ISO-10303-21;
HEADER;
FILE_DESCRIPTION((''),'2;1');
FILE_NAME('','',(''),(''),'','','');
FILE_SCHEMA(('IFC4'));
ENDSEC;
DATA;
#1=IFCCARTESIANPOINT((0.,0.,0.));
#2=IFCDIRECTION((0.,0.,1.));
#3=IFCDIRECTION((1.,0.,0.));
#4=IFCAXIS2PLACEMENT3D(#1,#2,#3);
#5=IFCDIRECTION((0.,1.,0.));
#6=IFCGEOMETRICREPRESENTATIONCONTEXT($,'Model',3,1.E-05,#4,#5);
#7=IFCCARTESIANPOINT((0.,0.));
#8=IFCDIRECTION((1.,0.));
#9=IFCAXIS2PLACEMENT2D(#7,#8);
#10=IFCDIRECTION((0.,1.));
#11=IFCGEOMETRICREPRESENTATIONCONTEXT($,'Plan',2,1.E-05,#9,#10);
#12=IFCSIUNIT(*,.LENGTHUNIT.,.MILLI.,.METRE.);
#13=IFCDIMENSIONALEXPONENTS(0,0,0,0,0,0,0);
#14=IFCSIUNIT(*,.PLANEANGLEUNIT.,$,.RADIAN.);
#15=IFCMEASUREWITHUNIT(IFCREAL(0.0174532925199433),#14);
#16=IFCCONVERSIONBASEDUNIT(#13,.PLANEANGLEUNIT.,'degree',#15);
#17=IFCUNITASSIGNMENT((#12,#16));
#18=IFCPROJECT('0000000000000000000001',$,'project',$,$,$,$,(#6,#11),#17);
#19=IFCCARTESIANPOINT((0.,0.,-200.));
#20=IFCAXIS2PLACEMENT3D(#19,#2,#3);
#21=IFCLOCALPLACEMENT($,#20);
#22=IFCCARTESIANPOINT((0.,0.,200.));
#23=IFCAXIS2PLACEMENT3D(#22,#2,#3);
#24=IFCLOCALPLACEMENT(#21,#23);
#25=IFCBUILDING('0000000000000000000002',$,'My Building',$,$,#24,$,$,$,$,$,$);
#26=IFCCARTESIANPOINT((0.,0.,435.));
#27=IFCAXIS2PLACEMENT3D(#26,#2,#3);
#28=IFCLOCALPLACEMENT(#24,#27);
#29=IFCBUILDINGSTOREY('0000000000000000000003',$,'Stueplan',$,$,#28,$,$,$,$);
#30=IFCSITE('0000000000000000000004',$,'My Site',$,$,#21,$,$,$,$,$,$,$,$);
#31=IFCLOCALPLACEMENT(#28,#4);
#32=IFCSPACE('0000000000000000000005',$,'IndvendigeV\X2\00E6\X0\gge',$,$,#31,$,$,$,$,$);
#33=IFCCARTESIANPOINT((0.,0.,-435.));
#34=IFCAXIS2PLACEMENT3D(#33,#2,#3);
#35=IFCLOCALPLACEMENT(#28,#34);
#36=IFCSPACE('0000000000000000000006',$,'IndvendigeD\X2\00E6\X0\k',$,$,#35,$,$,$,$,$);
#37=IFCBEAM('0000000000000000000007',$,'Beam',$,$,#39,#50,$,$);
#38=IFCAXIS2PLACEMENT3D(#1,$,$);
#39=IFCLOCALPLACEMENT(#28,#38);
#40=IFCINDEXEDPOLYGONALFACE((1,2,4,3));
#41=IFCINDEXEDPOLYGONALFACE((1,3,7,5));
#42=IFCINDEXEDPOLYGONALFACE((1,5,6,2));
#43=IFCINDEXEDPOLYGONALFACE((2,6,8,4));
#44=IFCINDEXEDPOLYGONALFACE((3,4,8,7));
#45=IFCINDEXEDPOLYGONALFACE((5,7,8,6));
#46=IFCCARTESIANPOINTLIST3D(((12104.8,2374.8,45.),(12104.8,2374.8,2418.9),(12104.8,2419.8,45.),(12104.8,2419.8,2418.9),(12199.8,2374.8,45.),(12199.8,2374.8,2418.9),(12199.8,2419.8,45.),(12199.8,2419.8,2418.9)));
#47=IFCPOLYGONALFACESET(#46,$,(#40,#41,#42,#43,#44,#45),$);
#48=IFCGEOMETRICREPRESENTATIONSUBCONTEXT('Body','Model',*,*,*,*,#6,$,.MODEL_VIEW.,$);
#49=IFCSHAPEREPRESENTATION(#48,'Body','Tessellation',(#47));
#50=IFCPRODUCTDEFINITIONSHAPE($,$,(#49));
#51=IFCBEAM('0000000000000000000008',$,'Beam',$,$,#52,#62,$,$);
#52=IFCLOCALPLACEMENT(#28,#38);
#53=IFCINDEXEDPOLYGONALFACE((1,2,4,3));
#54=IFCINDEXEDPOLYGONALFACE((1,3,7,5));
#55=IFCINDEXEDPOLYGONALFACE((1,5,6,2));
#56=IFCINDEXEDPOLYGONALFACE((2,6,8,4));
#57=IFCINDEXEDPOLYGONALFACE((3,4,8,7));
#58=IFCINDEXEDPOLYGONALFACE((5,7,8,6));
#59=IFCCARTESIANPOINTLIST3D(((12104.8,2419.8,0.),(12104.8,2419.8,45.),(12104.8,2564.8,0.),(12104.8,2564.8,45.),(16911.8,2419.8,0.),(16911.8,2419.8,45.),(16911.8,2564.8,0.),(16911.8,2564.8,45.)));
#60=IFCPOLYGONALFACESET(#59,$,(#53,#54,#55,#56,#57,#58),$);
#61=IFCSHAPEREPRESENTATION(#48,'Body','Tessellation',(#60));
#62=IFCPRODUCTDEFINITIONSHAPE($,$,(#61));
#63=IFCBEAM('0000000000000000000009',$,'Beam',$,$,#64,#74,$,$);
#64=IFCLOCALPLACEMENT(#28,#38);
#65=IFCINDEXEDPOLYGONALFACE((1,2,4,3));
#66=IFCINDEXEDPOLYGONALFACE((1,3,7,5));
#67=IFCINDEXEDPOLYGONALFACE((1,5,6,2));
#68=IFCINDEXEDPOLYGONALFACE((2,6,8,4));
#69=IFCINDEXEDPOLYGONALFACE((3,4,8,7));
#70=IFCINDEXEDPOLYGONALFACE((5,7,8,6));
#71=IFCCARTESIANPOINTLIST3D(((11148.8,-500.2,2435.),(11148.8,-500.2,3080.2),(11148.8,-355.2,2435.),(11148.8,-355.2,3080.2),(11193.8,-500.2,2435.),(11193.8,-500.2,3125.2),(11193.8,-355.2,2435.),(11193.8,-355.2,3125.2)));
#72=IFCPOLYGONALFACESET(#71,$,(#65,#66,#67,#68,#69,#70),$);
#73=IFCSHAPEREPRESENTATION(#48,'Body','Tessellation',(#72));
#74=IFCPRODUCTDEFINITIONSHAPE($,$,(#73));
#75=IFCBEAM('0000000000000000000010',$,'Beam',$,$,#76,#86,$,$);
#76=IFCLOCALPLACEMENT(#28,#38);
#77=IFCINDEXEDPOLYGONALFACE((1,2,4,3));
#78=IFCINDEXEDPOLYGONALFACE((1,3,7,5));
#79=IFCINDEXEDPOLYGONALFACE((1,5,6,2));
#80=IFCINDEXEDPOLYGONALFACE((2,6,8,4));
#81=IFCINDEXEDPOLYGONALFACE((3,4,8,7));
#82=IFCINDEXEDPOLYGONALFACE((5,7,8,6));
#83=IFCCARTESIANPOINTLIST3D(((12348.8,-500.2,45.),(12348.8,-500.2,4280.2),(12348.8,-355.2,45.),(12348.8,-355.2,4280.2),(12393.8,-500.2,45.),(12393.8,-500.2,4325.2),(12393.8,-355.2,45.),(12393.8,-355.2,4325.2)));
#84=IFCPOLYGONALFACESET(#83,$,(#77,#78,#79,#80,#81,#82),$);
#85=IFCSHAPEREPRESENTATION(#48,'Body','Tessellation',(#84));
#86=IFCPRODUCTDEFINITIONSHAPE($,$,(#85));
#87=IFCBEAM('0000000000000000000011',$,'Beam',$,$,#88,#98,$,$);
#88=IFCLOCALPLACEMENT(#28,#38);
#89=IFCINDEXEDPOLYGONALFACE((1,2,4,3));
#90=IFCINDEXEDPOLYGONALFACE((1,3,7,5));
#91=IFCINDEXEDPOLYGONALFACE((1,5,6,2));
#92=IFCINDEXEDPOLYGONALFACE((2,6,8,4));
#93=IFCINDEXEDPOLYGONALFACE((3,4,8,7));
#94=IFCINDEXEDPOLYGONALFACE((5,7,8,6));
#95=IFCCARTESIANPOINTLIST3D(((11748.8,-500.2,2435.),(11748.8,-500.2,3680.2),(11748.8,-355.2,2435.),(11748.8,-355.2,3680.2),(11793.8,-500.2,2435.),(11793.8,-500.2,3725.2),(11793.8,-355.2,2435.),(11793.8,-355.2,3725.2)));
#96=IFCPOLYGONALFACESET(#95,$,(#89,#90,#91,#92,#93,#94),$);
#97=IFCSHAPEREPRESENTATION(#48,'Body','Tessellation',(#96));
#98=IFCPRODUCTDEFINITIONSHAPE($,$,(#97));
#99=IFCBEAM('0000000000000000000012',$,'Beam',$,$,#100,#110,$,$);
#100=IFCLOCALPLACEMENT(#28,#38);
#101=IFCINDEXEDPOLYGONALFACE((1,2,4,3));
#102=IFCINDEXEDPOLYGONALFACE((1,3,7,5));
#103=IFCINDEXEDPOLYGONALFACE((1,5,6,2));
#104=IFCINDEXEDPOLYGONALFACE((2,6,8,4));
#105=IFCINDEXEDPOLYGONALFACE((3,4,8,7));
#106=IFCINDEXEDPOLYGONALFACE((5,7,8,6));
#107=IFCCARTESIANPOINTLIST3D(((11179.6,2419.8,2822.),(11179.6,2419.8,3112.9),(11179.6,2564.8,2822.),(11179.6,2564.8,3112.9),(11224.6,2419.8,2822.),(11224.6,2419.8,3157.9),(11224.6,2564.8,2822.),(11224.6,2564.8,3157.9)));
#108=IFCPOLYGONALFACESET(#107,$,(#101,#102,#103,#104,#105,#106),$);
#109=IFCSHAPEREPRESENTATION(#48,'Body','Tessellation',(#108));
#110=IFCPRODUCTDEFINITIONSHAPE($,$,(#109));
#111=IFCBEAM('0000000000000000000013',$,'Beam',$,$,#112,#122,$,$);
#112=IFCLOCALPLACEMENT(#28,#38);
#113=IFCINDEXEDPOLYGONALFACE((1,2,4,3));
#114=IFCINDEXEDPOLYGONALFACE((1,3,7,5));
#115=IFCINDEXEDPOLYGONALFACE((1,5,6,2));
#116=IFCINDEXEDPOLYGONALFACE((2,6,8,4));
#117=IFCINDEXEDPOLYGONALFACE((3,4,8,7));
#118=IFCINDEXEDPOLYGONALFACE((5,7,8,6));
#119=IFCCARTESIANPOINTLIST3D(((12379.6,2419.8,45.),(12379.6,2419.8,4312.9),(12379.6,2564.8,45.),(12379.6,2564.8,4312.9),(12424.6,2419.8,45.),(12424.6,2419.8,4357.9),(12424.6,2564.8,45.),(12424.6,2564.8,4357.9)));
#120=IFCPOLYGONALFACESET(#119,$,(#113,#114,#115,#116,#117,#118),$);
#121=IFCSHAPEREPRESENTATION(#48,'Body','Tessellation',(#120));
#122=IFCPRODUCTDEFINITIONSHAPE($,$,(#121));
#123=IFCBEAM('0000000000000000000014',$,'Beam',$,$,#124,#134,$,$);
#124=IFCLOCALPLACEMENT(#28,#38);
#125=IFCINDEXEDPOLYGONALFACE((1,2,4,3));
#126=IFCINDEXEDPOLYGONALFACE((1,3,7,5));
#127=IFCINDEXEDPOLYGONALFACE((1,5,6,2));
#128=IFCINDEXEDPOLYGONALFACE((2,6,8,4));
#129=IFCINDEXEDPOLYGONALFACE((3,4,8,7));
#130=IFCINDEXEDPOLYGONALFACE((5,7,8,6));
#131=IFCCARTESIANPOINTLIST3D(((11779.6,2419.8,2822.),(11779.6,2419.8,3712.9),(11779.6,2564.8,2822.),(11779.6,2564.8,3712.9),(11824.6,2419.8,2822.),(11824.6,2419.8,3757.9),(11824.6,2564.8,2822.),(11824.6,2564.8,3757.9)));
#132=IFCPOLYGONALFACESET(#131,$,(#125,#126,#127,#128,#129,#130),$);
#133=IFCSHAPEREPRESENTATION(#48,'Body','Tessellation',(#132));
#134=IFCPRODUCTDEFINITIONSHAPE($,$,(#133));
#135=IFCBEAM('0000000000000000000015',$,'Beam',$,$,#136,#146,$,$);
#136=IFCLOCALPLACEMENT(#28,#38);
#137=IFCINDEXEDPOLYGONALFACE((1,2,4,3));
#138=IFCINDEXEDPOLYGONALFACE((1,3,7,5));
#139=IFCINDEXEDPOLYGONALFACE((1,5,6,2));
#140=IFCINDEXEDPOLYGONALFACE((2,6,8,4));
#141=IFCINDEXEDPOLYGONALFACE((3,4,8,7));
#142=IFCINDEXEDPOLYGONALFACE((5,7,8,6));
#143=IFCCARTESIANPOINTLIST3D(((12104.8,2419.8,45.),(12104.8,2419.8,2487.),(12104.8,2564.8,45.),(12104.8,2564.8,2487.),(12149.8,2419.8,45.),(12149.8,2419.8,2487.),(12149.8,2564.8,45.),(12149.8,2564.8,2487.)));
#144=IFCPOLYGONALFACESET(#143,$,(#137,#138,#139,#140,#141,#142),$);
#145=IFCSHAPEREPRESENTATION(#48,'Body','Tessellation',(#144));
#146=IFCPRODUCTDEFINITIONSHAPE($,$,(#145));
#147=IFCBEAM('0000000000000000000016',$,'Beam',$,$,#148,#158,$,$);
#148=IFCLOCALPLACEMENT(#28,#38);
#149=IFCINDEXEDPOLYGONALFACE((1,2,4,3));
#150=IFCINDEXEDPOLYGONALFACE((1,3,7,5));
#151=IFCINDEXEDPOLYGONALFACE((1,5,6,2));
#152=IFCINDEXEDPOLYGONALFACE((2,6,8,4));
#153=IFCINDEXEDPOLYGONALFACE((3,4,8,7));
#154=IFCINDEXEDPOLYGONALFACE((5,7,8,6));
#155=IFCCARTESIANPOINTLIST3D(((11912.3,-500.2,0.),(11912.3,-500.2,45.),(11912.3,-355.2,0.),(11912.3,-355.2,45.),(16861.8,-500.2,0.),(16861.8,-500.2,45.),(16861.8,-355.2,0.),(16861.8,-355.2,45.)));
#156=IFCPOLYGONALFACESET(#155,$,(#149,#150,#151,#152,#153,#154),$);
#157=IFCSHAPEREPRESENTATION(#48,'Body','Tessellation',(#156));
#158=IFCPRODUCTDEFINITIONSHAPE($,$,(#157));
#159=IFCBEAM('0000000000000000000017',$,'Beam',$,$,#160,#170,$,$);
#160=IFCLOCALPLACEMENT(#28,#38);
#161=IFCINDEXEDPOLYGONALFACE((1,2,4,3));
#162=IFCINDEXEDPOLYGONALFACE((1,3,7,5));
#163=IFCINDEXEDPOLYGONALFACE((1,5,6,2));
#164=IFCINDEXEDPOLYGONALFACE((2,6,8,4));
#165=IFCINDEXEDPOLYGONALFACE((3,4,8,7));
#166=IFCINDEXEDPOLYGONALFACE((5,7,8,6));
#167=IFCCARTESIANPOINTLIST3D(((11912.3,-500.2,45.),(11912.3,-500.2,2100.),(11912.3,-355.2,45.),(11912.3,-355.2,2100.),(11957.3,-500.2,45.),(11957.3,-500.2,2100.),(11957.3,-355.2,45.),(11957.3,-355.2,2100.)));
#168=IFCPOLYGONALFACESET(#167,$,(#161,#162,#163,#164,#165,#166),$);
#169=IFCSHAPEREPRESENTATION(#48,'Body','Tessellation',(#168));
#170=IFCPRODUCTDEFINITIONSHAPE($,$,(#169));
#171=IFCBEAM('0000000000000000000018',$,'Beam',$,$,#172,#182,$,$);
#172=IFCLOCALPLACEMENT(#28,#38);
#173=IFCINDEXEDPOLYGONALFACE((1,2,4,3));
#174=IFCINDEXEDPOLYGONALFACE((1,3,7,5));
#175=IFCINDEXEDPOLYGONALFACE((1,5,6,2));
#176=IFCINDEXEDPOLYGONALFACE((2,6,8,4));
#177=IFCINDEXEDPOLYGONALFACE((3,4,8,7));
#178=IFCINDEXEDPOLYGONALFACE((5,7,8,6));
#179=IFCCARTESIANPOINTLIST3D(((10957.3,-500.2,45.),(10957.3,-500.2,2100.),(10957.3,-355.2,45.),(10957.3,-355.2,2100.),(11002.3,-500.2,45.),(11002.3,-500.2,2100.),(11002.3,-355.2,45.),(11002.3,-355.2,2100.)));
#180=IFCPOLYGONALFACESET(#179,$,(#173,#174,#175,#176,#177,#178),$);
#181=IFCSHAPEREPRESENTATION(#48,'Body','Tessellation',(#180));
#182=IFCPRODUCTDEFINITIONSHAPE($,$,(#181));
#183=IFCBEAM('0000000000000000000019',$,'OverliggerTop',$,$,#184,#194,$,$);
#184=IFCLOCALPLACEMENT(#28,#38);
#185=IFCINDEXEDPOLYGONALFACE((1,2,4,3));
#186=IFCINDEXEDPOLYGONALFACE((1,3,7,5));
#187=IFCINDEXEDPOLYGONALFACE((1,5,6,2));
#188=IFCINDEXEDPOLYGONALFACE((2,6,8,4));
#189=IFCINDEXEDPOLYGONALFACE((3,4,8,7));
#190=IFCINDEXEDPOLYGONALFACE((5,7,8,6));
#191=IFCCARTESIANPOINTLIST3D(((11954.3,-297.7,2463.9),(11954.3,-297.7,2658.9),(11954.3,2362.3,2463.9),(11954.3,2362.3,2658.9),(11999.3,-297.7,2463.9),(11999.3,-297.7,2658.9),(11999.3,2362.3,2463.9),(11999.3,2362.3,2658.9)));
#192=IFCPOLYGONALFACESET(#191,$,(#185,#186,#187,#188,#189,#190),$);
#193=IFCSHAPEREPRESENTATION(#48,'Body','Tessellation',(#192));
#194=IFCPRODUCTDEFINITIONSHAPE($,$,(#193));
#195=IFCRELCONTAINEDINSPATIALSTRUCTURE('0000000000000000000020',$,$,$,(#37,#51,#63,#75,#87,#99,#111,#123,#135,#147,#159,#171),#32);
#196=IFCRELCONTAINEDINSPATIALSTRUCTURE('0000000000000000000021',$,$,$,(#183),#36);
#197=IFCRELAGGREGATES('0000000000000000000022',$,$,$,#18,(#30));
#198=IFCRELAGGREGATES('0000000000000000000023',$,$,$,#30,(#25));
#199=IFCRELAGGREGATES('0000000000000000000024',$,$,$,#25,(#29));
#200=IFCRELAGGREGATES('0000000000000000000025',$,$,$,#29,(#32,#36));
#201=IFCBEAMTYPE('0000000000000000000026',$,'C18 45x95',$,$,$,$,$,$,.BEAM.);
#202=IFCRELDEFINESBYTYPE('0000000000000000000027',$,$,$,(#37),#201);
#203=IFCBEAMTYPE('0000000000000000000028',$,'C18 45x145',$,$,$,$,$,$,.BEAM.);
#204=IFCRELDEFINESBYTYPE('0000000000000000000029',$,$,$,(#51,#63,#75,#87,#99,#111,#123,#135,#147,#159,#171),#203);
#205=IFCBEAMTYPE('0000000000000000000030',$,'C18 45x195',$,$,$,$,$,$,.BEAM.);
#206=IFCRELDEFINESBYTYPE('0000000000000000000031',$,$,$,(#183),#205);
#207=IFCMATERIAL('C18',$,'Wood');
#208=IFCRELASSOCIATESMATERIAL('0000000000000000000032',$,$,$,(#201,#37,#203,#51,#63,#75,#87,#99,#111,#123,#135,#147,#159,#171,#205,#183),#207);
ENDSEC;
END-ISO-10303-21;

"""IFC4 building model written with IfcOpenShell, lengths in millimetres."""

from ifc_helpers import new_model, entity, si_unit, converted_unit, direction, frame, origin_with_axes, origin_2d_with_axis, place, context, subcontext, project, spatial, rectangle, extrude, clip, halfspace, material, material_profile, profile_set, profile_usage, type_object, element, save


model = new_model("IFC4")

# Units and contexts
model_context = context("Model", 3, precision=1e-05, world=origin_with_axes(), true_north=direction((0.0, 1.0, 0.0)))
plan_context = context("Plan", 2, precision=1e-05, world=origin_2d_with_axis(), true_north=direction((0.0, 1.0)))
body_context_1 = subcontext(model_context, "Body", "Model", "MODEL_VIEW")
ifc_project = project(units=[si_unit("LENGTHUNIT", "METRE", prefix="MILLI"), converted_unit("PLANEANGLEUNIT", "degree", entity("IfcReal", 0.0174532925199433), si_unit("PLANEANGLEUNIT", "RADIAN"), dimensions=[0, 0, 0, 0, 0, 0, 0])], contexts=[model_context, plan_context])

# Site, building, storey
site_placement = place(None, frame((0.0, 0.0, -200.0), z_axis=(0.0, 0.0, 1.0), x_axis=(1.0, 0.0, 0.0)))
site = spatial("IfcSite", under=ifc_project, at=site_placement, Name="My Site")
building_placement = place(site_placement, frame((0.0, 0.0, 200.0), z_axis=(0.0, 0.0, 1.0), x_axis=(1.0, 0.0, 0.0)))
building = spatial("IfcBuilding", under=site, at=building_placement, Name="My Building")
storey_placement = place(building_placement, frame((0.0, 0.0, 435.0), z_axis=(0.0, 0.0, 1.0), x_axis=(1.0, 0.0, 0.0)))
storey = spatial("IfcBuildingStorey", under=building, at=storey_placement, Name="Stueplan")

# Shared definitions
ifc_material = material(Name="C18", Category="Wood")

# Shared definitions
space_1_placement = place(storey_placement, frame((0.0, 0.0, 0.0), z_axis=(0.0, 0.0, 1.0), x_axis=(1.0, 0.0, 0.0)))
space_1 = spatial("IfcSpace", under=storey, at=space_1_placement, Name="IndvendigeVægge")

# Beams
ifc_material_profile_1 = material_profile(ifc_material, rectangle(XDim=45.0, YDim=95.0))
ifc_profile_set_1 = profile_set([ifc_material_profile_1], Name="woodStructural")
beam_type_1 = type_object("IfcBeamType", Name="C18 45x95", PredefinedType="BEAM", material=ifc_profile_set_1)
ifc_profile_usage_1 = profile_usage(ifc_profile_set_1)
beam_1_placement = place(space_1_placement, frame((12152.3, 2397.3, 45.0), z_axis=(0.0, 0.0, 1.0), x_axis=(0.0, 1.0, 0.0)))
element("IfcBeam", 1, at=beam_1_placement, inside=space_1, type_object=beam_type_1, material=ifc_profile_usage_1, Name="Beam", context=body_context_1, shape_type="SweptSolid", body=[
    extrude(rectangle(XDim=45.0, YDim=95.0), origin_with_axes(), (0.0, 0.0, 1.0), 2373.9),
])
ifc_material_profile_2 = material_profile(ifc_material, rectangle(XDim=45.0, YDim=145.0))
ifc_profile_set_2 = profile_set([ifc_material_profile_2], Name="woodStructural")
ifc_profile_usage_2 = profile_usage(ifc_profile_set_2)
beam_type_2 = type_object("IfcBeamType", Name="C18 45x145", PredefinedType="BEAM", material=ifc_profile_set_2)
beam_2_placement = place(space_1_placement, frame((12104.8, 2492.3, 22.5), z_axis=(1.0, 0.0, 0.0), x_axis=(0.0, 0.0, 1.0)))
element("IfcBeam", 2, at=beam_2_placement, inside=space_1, type_object=beam_type_2, material=ifc_profile_usage_2, Name="Beam", context=body_context_1, shape_type="SweptSolid", body=[
    extrude(rectangle(XDim=45.0, YDim=145.0), origin_with_axes(), (0.0, 0.0, 1.0), 4807.0),
])
ifc_profile_usage_3 = profile_usage(ifc_profile_set_2)
beam_3_placement = place(space_1_placement, frame((11171.3, -427.7, 2435.0), z_axis=(0.0, 0.0, 1.0), x_axis=(-1.0, 0.0, 0.0)))
element("IfcBeam", 3, at=beam_3_placement, inside=space_1, type_object=beam_type_2, material=ifc_profile_usage_3, Name="Beam", context=body_context_1, shape_type="Clipping", body=[
    clip(extrude(rectangle(XDim=45.0, YDim=145.0), origin_with_axes(), (0.0, 0.0, 1.0), 812.7), halfspace(frame((-2746.1, 0.0, 3413.8), z_axis=(0.707107, 0.0, 0.707107), x_axis=(0.0, -1.0, 0.0)), False)),
])
ifc_profile_usage_4 = profile_usage(ifc_profile_set_2)
beam_4_placement = place(space_1_placement, frame((12371.3, -427.7, 45.0), z_axis=(0.0, 0.0, 1.0), x_axis=(-1.0, 0.0, 0.0)))
element("IfcBeam", 4, at=beam_4_placement, inside=space_1, type_object=beam_type_2, material=ifc_profile_usage_4, Name="Beam", context=body_context_1, shape_type="Clipping", body=[
    clip(extrude(rectangle(XDim=45.0, YDim=145.0), origin_with_axes(), (0.0, 0.0, 1.0), 4402.7), halfspace(frame((-1546.1, 0.0, 5803.8), z_axis=(0.707107, 0.0, 0.707107), x_axis=(0.0, -1.0, 0.0)), False)),
])
ifc_profile_usage_5 = profile_usage(ifc_profile_set_2)
beam_5_placement = place(space_1_placement, frame((11771.3, -427.7, 2435.0), z_axis=(0.0, 0.0, 1.0), x_axis=(-1.0, 0.0, 0.0)))
element("IfcBeam", 5, at=beam_5_placement, inside=space_1, type_object=beam_type_2, material=ifc_profile_usage_5, Name="Beam", context=body_context_1, shape_type="Clipping", body=[
    clip(extrude(rectangle(XDim=45.0, YDim=145.0), origin_with_axes(), (0.0, 0.0, 1.0), 1412.7), halfspace(frame((-2146.1, 0.0, 3413.8), z_axis=(0.707107, 0.0, 0.707107), x_axis=(0.0, -1.0, 0.0)), False)),
])
ifc_profile_usage_6 = profile_usage(ifc_profile_set_2)
beam_6_placement = place(space_1_placement, frame((11202.1, 2492.3, 2822.0), z_axis=(0.0, 0.0, 1.0), x_axis=(-1.0, 0.0, 0.0)))
element("IfcBeam", 6, at=beam_6_placement, inside=space_1, type_object=beam_type_2, material=ifc_profile_usage_6, Name="Beam", context=body_context_1, shape_type="Clipping", body=[
    clip(extrude(rectangle(XDim=45.0, YDim=145.0), origin_with_axes(), (0.0, 0.0, 1.0), 458.4), halfspace(frame((-2626.2, 0.0, 2939.6), z_axis=(0.707107, 0.0, 0.707107), x_axis=(0.0, -1.0, 0.0)), False)),
])
ifc_profile_usage_7 = profile_usage(ifc_profile_set_2)
beam_7_placement = place(space_1_placement, frame((12402.1, 2492.3, 45.0), z_axis=(0.0, 0.0, 1.0), x_axis=(-1.0, 0.0, 0.0)))
element("IfcBeam", 7, at=beam_7_placement, inside=space_1, type_object=beam_type_2, material=ifc_profile_usage_7, Name="Beam", context=body_context_1, shape_type="Clipping", body=[
    clip(extrude(rectangle(XDim=45.0, YDim=145.0), origin_with_axes(), (0.0, 0.0, 1.0), 4435.4), halfspace(frame((-1439.0, 0.0, 5729.4), z_axis=(0.707107, 0.0, 0.707107), x_axis=(0.0, -1.0, 0.0)), False)),
])
ifc_profile_usage_8 = profile_usage(ifc_profile_set_2)
beam_8_placement = place(space_1_placement, frame((11802.1, 2492.3, 2822.0), z_axis=(0.0, 0.0, 1.0), x_axis=(-1.0, 0.0, 0.0)))
element("IfcBeam", 8, at=beam_8_placement, inside=space_1, type_object=beam_type_2, material=ifc_profile_usage_8, Name="Beam", context=body_context_1, shape_type="Clipping", body=[
    clip(extrude(rectangle(XDim=45.0, YDim=145.0), origin_with_axes(), (0.0, 0.0, 1.0), 1058.4), halfspace(frame((-2026.2, 0.0, 2939.6), z_axis=(0.707107, 0.0, 0.707107), x_axis=(0.0, -1.0, 0.0)), False)),
])
ifc_profile_usage_9 = profile_usage(ifc_profile_set_2)
beam_9_placement = place(space_1_placement, frame((12127.3, 2492.3, 45.0), z_axis=(0.0, 0.0, 1.0), x_axis=(-1.0, 0.0, 0.0)))
element("IfcBeam", 9, at=beam_9_placement, inside=space_1, type_object=beam_type_2, material=ifc_profile_usage_9, Name="Beam", context=body_context_1, shape_type="SweptSolid", body=[
    extrude(rectangle(XDim=45.0, YDim=145.0), origin_with_axes(), (0.0, 0.0, 1.0), 2442.0),
])
ifc_profile_usage_10 = profile_usage(ifc_profile_set_2)
beam_10_placement = place(space_1_placement, frame((11912.3, -427.7, 22.5), z_axis=(1.0, 0.0, 0.0), x_axis=(0.0, 0.0, 1.0)))
element("IfcBeam", 10, at=beam_10_placement, inside=space_1, type_object=beam_type_2, material=ifc_profile_usage_10, Name="Beam", context=body_context_1, shape_type="SweptSolid", body=[
    extrude(rectangle(XDim=45.0, YDim=145.0), origin_with_axes(), (0.0, 0.0, 1.0), 4949.5),
])
ifc_profile_usage_11 = profile_usage(ifc_profile_set_2)
beam_11_placement = place(space_1_placement, frame((11934.8, -427.7, 45.0), z_axis=(0.0, 0.0, 1.0), x_axis=(-1.0, 0.0, 0.0)))
element("IfcBeam", 11, at=beam_11_placement, inside=space_1, type_object=beam_type_2, material=ifc_profile_usage_11, Name="Beam", context=body_context_1, shape_type="SweptSolid", body=[
    extrude(rectangle(XDim=45.0, YDim=145.0), origin_with_axes(), (0.0, 0.0, 1.0), 2055.0),
])
ifc_profile_usage_12 = profile_usage(ifc_profile_set_2)
beam_12_placement = place(space_1_placement, frame((10979.8, -427.7, 45.0), z_axis=(0.0, 0.0, 1.0), x_axis=(-1.0, 0.0, 0.0)))
element("IfcBeam", 12, at=beam_12_placement, inside=space_1, type_object=beam_type_2, material=ifc_profile_usage_12, Name="Beam", context=body_context_1, shape_type="SweptSolid", body=[
    extrude(rectangle(XDim=45.0, YDim=145.0), origin_with_axes(), (0.0, 0.0, 1.0), 2055.0),
])

# Shared definitions
space_2_placement = place(storey_placement, frame((0.0, 0.0, -435.0), z_axis=(0.0, 0.0, 1.0), x_axis=(1.0, 0.0, 0.0)))
space_2 = spatial("IfcSpace", under=storey, at=space_2_placement, Name="IndvendigeDæk")

# Beam
ifc_material_profile_3 = material_profile(ifc_material, rectangle(XDim=45.0, YDim=195.0))
ifc_profile_set_3 = profile_set([ifc_material_profile_3], Name="woodStructural")
ifc_profile_usage_13 = profile_usage(ifc_profile_set_3)
beam_type_3 = type_object("IfcBeamType", Name="C18 45x195", PredefinedType="BEAM", material=ifc_profile_set_3)
beam_13_placement = place(space_2_placement, frame((11976.8, 2362.3, 2996.4), z_axis=(0.000001, -1.0, 0.0), x_axis=(-1.0, -0.000001, 0.0)))
element("IfcBeam", 13, at=beam_13_placement, inside=space_2, type_object=beam_type_3, material=ifc_profile_usage_13, Name="OverliggerTop", context=body_context_1, shape_type="SweptSolid", body=[
    extrude(rectangle(XDim=45.0, YDim=195.0), origin_with_axes(), (0.0, 0.0, 1.0), 2660.0),
])

save(model, "model.ifc")
